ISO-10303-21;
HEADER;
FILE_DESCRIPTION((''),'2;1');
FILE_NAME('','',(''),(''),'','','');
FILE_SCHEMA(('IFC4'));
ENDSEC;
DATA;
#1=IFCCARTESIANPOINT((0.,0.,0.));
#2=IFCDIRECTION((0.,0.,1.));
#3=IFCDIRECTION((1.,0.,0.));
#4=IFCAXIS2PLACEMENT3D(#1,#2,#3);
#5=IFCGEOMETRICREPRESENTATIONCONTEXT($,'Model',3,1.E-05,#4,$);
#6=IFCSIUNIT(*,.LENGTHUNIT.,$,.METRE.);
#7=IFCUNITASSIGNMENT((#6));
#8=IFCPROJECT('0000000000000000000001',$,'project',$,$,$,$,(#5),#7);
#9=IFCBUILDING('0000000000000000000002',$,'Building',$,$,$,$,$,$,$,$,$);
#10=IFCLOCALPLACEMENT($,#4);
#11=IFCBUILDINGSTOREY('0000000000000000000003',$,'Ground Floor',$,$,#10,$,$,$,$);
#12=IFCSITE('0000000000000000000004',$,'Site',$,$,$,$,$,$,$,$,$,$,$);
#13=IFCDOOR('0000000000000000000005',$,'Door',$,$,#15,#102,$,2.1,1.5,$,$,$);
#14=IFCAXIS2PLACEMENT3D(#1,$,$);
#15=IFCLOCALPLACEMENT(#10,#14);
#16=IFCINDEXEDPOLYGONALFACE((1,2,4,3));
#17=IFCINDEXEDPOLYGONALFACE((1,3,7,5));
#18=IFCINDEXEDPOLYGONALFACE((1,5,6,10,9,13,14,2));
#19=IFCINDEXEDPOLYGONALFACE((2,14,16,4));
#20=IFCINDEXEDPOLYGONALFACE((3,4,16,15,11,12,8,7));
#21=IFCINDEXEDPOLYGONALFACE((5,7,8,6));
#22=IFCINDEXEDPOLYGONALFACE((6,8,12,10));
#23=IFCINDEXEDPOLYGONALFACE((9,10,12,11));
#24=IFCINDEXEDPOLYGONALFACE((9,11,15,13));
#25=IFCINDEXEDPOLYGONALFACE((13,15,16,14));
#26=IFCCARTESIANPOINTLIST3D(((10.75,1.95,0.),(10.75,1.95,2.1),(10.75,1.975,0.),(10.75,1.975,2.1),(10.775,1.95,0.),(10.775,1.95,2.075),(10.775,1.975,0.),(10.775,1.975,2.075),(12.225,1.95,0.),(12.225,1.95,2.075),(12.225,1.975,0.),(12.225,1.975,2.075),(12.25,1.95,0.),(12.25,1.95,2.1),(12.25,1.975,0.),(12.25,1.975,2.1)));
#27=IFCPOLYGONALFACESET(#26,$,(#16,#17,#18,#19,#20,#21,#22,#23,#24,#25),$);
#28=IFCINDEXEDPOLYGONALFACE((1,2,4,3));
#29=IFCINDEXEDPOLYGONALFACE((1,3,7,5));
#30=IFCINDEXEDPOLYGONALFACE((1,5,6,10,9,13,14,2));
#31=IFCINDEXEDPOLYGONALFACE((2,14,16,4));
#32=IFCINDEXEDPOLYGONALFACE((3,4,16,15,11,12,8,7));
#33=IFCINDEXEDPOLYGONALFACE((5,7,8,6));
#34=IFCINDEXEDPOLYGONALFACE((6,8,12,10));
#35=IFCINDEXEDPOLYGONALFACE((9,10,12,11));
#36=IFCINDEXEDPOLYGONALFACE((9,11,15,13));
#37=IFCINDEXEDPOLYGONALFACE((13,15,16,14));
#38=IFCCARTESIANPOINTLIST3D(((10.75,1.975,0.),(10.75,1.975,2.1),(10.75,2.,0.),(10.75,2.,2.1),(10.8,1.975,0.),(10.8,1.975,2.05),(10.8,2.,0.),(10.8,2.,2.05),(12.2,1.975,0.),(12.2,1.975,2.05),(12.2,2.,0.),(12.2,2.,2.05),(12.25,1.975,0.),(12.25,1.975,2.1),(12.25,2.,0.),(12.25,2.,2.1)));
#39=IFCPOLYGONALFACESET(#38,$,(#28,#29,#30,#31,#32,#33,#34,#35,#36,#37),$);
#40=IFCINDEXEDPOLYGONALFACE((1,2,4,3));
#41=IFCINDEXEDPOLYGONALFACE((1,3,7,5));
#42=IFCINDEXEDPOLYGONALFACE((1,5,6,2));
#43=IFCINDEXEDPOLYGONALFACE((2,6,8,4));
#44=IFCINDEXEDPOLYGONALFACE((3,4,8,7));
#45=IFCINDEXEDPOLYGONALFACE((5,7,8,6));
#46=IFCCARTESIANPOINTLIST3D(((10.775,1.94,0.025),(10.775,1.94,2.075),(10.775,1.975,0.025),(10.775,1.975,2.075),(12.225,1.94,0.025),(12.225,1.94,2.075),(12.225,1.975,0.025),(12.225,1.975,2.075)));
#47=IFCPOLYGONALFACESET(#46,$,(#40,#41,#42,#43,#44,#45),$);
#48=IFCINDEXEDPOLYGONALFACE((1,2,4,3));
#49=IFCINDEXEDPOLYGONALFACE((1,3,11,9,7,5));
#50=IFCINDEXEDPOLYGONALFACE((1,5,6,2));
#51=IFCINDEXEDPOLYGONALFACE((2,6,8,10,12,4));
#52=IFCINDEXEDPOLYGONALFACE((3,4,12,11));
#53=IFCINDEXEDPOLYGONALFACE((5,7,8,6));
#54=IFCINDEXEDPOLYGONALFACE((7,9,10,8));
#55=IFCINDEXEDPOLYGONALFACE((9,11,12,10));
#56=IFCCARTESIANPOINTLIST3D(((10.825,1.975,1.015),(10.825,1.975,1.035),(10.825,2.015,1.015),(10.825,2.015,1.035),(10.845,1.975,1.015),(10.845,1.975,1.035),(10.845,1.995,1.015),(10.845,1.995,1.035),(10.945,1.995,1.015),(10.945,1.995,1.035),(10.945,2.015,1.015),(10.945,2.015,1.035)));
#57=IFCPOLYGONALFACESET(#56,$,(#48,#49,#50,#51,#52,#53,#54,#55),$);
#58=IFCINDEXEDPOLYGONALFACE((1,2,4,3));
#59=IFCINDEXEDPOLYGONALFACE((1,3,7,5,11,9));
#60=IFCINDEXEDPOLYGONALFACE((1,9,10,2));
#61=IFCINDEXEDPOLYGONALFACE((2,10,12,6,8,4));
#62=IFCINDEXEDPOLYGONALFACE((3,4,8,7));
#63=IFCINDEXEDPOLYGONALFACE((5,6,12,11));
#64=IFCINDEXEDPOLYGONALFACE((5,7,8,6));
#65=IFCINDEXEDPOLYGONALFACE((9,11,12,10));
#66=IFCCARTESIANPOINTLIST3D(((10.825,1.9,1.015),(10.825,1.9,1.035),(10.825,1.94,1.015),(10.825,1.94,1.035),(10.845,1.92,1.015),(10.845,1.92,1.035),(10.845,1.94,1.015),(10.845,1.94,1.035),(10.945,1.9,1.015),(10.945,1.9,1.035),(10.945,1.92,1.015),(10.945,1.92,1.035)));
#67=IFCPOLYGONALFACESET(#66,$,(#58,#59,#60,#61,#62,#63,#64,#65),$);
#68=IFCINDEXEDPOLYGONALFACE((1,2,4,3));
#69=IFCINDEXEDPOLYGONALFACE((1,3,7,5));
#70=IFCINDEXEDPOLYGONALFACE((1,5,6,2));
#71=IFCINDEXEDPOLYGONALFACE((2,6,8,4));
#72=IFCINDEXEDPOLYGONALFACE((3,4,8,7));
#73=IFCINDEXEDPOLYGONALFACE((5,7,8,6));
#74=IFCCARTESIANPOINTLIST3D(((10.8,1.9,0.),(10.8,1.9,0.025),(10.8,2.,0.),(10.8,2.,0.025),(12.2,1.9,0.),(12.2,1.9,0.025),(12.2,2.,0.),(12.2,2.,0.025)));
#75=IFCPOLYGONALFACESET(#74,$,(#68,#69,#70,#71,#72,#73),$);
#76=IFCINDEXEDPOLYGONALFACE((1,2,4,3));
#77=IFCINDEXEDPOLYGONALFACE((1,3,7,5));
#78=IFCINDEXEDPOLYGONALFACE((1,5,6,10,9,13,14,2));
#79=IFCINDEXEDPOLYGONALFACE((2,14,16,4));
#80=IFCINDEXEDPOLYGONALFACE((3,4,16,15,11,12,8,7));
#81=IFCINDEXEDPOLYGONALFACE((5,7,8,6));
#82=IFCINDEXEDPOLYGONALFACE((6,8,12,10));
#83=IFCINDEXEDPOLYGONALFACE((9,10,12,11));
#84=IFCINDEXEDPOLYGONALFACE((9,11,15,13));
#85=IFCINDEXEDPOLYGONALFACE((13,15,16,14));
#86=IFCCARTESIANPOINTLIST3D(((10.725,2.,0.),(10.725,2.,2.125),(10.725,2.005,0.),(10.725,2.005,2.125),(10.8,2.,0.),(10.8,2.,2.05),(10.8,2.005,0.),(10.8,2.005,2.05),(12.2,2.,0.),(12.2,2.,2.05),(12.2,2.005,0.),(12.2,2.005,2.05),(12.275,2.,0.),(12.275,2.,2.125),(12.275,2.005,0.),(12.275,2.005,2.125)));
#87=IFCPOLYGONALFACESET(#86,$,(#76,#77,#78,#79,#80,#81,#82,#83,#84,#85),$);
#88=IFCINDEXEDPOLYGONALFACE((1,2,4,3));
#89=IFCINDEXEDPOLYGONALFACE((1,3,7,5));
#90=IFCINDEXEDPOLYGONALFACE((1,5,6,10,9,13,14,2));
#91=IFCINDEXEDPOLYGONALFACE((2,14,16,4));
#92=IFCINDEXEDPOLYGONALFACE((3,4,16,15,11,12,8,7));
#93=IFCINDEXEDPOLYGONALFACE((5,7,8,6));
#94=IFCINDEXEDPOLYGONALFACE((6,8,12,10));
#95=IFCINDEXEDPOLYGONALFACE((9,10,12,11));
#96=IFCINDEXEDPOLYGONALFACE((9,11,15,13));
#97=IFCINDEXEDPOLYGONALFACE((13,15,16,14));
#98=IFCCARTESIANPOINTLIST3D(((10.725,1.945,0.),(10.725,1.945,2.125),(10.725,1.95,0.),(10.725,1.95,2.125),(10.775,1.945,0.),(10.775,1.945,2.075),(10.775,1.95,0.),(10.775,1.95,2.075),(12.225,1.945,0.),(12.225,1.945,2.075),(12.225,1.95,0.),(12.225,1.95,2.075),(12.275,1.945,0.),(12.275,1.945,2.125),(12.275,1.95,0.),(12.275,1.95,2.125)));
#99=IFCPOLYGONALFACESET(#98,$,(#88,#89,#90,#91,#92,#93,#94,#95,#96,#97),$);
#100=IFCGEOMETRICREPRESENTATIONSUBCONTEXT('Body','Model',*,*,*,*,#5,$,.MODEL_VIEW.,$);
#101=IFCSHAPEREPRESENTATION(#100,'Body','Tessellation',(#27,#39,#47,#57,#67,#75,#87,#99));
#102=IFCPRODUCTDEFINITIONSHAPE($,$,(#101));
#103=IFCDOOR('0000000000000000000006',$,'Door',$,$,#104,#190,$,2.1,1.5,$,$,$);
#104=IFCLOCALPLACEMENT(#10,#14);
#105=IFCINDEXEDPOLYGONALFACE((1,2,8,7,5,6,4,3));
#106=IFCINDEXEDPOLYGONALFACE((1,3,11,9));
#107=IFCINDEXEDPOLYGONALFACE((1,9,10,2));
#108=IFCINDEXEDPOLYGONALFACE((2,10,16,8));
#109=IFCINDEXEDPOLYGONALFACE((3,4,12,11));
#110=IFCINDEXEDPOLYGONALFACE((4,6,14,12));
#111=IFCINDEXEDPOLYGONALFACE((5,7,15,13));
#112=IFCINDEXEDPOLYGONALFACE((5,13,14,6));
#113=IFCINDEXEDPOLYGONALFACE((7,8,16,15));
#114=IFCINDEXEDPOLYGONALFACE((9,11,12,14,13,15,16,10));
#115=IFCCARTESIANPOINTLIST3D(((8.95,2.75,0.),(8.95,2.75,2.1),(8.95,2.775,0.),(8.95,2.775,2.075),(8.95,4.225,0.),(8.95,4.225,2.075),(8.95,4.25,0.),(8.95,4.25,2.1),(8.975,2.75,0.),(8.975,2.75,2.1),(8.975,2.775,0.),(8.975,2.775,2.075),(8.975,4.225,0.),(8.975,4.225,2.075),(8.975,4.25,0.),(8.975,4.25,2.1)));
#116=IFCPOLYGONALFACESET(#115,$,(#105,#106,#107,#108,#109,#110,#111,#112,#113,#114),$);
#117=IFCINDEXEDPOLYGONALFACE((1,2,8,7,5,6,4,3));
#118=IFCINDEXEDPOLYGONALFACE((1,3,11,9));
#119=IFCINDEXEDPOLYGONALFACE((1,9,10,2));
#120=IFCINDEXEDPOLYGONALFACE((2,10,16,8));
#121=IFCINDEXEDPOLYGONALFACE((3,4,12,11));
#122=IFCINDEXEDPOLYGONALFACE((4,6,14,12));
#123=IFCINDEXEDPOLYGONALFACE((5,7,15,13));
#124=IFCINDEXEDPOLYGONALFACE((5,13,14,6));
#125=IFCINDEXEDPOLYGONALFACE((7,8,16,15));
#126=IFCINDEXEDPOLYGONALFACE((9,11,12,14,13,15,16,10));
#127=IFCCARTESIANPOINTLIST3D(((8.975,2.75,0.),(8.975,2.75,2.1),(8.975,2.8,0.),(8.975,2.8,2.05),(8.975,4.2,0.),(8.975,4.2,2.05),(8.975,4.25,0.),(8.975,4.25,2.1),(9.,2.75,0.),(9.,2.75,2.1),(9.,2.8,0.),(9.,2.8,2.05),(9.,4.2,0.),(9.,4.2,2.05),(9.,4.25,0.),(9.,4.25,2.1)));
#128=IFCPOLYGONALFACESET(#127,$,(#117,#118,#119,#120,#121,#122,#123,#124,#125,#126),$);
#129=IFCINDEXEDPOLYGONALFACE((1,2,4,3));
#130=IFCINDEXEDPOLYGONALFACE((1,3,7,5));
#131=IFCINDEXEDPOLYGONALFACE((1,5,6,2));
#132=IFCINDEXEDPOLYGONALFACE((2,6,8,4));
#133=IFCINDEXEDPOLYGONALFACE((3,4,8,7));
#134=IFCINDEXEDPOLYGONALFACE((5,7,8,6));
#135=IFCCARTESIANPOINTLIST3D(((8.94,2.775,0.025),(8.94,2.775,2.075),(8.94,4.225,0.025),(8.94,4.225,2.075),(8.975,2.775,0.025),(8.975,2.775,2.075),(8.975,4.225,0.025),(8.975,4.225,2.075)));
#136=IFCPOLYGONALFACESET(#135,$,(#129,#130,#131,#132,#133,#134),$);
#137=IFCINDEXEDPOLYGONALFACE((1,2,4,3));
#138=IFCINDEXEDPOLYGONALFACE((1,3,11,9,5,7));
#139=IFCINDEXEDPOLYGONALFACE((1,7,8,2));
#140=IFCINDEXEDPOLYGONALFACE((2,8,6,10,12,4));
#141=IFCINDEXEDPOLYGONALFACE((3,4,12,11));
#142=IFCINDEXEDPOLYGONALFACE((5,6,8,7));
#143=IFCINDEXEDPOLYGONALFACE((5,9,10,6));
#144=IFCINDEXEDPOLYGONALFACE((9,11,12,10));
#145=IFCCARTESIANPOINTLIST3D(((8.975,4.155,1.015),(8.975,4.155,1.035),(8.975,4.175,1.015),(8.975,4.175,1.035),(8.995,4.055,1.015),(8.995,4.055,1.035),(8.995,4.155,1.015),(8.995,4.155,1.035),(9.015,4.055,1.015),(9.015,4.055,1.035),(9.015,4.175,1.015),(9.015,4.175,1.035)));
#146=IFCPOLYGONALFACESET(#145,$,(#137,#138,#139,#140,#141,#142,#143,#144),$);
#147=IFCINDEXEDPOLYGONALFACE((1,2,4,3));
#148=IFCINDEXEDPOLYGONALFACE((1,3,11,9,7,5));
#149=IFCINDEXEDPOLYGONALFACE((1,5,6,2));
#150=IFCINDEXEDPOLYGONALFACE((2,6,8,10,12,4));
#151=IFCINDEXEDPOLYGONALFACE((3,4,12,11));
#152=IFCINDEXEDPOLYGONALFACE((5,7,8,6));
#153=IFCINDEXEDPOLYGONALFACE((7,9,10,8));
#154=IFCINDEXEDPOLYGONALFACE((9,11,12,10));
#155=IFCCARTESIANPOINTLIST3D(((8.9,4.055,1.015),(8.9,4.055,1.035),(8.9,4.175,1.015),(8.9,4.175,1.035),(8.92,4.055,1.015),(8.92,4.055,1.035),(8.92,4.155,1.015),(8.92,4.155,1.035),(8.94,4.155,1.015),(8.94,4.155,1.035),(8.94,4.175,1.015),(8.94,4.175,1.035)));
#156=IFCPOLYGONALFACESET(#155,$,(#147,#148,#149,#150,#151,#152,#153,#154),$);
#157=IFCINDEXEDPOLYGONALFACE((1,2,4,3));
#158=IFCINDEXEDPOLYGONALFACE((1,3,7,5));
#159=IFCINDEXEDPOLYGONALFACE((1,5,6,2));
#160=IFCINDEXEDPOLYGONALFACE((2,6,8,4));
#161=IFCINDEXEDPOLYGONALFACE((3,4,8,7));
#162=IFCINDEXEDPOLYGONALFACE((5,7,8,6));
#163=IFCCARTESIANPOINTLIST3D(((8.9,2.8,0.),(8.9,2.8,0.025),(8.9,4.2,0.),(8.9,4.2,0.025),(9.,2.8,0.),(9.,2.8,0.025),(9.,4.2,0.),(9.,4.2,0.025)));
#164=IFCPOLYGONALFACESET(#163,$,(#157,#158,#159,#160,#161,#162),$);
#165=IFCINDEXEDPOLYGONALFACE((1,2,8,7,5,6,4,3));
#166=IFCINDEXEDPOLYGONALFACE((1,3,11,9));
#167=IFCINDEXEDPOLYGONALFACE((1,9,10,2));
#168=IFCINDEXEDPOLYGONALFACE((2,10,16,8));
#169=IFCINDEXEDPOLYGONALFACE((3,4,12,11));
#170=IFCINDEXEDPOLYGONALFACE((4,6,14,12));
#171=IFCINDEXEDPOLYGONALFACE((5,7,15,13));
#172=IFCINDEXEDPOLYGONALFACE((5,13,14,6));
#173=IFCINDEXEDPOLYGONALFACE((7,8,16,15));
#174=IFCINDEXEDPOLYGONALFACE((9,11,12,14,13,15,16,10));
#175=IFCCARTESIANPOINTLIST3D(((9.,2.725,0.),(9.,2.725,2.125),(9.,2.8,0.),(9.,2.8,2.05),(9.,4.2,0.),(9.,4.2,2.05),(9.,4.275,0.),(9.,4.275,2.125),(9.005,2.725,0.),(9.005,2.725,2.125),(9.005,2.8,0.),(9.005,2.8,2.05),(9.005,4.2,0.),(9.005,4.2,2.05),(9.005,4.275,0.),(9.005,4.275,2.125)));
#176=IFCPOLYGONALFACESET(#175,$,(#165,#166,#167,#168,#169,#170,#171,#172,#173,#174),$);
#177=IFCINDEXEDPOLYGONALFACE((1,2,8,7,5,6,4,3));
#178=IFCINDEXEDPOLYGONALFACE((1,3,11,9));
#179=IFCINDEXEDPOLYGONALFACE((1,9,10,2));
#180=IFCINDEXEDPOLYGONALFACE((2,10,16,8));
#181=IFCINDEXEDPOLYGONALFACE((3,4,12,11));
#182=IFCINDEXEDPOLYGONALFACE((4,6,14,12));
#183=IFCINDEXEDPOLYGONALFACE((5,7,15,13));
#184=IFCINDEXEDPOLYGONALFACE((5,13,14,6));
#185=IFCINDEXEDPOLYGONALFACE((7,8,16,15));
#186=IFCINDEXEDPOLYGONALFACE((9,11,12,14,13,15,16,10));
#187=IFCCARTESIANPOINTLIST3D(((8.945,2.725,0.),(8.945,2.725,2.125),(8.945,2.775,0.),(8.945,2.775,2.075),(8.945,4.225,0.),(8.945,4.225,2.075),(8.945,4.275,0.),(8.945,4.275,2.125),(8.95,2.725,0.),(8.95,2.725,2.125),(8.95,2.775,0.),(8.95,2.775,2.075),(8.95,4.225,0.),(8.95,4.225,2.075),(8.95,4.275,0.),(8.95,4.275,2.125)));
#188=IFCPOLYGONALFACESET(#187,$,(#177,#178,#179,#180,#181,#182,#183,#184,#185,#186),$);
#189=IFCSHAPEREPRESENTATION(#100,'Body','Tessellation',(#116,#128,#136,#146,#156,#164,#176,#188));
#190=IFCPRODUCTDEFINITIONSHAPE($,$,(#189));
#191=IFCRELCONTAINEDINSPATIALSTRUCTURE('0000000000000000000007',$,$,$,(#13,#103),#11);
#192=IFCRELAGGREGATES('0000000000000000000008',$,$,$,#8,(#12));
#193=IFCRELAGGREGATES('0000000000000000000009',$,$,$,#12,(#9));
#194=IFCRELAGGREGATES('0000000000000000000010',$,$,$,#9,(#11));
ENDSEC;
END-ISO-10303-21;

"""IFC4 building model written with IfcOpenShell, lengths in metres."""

from ifc_helpers import new_model, si_unit, frame, origin_with_axes, place, context, subcontext, project, spatial, line, indexed_curve, outline, extrude, element, save


model = new_model("IFC4")

# Units and contexts
model_context = context("Model", 3, precision=1e-05, world=origin_with_axes())
body_context = subcontext(model_context, "Body", "Model", "MODEL_VIEW")
ifc_project = project(units=[si_unit("LENGTHUNIT", "METRE")], contexts=[model_context])

# Site, building, storey
site = spatial("IfcSite", under=ifc_project, Name="Site")
building = spatial("IfcBuilding", under=site, Name="Building")
storey_placement = place(None, origin_with_axes())
storey = spatial("IfcBuildingStorey", under=building, at=storey_placement, Name="Ground Floor")

# Doors
door_1_placement = place(storey_placement, frame((12.25, 2.0, 0.0), z_axis=(0.0, 0.0, 1.0), x_axis=(-1.0, 0.0, 0.0)))
element("IfcDoor", 1, at=door_1_placement, inside=storey, Name="Door", OverallHeight=2.1, OverallWidth=1.5, context=body_context, shape_type="SweptSolid", body=[
    extrude(outline(indexed_curve([(0.0, 0.0), (0.0, 2.1), (1.5, 2.1), (1.5, 0.0), (1.475, 0.0), (1.475, 2.075), (0.025, 2.075), (0.025, 0.0)], segments=[line(1, 2, 3, 4, 5, 6, 7, 8, 1)])), frame((0.0, 0.025, 0.0), z_axis=(0.0, -1.0, 0.0), x_axis=(1.0, 0.0, 0.0)), (0.0, 0.0, -1.0), 0.025),
    extrude(outline(indexed_curve([(0.0, 0.0), (0.0, 2.1), (1.5, 2.1), (1.5, 0.0), (1.45, 0.0), (1.45, 2.05), (0.05, 2.05), (0.05, 0.0)], segments=[line(1, 2, 3, 4, 5, 6, 7, 8, 1)])), frame((0.0, 0.0, 0.0), z_axis=(0.0, -1.0, 0.0), x_axis=(1.0, 0.0, 0.0)), (0.0, 0.0, -1.0), 0.025),
    extrude(outline(indexed_curve([(0.0, 0.0), (1.45, 0.0), (1.45, 0.035), (0.0, 0.035)], segments=[line(1, 2, 3, 4, 1)])), frame((0.025, 0.025, 0.025), z_axis=(0.0, 0.0, 1.0), x_axis=(1.0, 0.0, 0.0)), (0.0, 0.0, 1.0), 2.05),
    extrude(outline(indexed_curve([(0.0, 0.0), (0.0, -0.04), (-0.12, -0.04), (-0.12, -0.02), (-0.02, -0.02), (-0.02, 0.0)], segments=[line(1, 2, 3, 4, 5, 6, 1)])), frame((1.425, 0.025, 1.015), z_axis=(0.0, 0.0, 1.0), x_axis=(1.0, 0.0, 0.0)), (0.0, 0.0, 1.0), 0.02),
    extrude(outline(indexed_curve([(0.0, 0.0), (0.0, 0.04), (-0.12, 0.04), (-0.12, 0.02), (-0.02, 0.02), (-0.02, 0.0)], segments=[line(1, 2, 3, 4, 5, 6, 1)])), frame((1.425, 0.06, 1.015), z_axis=(0.0, 0.0, 1.0), x_axis=(1.0, 0.0, 0.0)), (0.0, 0.0, 1.0), 0.02),
    extrude(outline(indexed_curve([(0.0, 0.0), (1.4, 0.0), (1.4, 0.1), (0.0, 0.1)], segments=[line(1, 2, 3, 4, 1)])), frame((0.05, 0.0, 0.0), z_axis=(0.0, 0.0, 1.0), x_axis=(1.0, 0.0, 0.0)), (0.0, 0.0, 1.0), 0.025),
    extrude(outline(indexed_curve([(0.0, 0.0), (0.0, 2.125), (1.55, 2.125), (1.55, 0.0), (1.475, 0.0), (1.475, 2.05), (0.075, 2.05), (0.075, 0.0)], segments=[line(1, 2, 3, 4, 5, 6, 7, 8, 1)])), frame((-0.025, -0.005, 0.0), z_axis=(0.0, -1.0, 0.0), x_axis=(1.0, 0.0, 0.0)), (0.0, 0.0, -1.0), 0.005),
    extrude(outline(indexed_curve([(0.0, 0.0), (0.0, 2.125), (1.55, 2.125), (1.55, 0.0), (1.5, 0.0), (1.5, 2.075), (0.05, 2.075), (0.05, 0.0)], segments=[line(1, 2, 3, 4, 5, 6, 7, 8, 1)])), frame((-0.025, 0.05, 0.0), z_axis=(0.0, -1.0, 0.0), x_axis=(1.0, 0.0, 0.0)), (0.0, 0.0, -1.0), 0.005),
])
door_2_placement = place(storey_placement, frame((9.0, 2.75, 0.0), z_axis=(0.0, 0.0, 1.0), x_axis=(0.0, 1.0, 0.0)))
element("IfcDoor", 2, at=door_2_placement, inside=storey, Name="Door", OverallHeight=2.1, OverallWidth=1.5, context=body_context, shape_type="SweptSolid", body=[
    extrude(outline(indexed_curve([(0.0, 0.0), (0.0, 2.1), (1.5, 2.1), (1.5, 0.0), (1.475, 0.0), (1.475, 2.075), (0.025, 2.075), (0.025, 0.0)], segments=[line(1, 2, 3, 4, 5, 6, 7, 8, 1)])), frame((0.0, 0.025, 0.0), z_axis=(0.0, -1.0, 0.0), x_axis=(1.0, 0.0, 0.0)), (0.0, 0.0, -1.0), 0.025),
    extrude(outline(indexed_curve([(0.0, 0.0), (0.0, 2.1), (1.5, 2.1), (1.5, 0.0), (1.45, 0.0), (1.45, 2.05), (0.05, 2.05), (0.05, 0.0)], segments=[line(1, 2, 3, 4, 5, 6, 7, 8, 1)])), frame((0.0, 0.0, 0.0), z_axis=(0.0, -1.0, 0.0), x_axis=(1.0, 0.0, 0.0)), (0.0, 0.0, -1.0), 0.025),
    extrude(outline(indexed_curve([(0.0, 0.0), (1.45, 0.0), (1.45, 0.035), (0.0, 0.035)], segments=[line(1, 2, 3, 4, 1)])), frame((0.025, 0.025, 0.025), z_axis=(0.0, 0.0, 1.0), x_axis=(1.0, 0.0, 0.0)), (0.0, 0.0, 1.0), 2.05),
    extrude(outline(indexed_curve([(0.0, 0.0), (0.0, -0.04), (-0.12, -0.04), (-0.12, -0.02), (-0.02, -0.02), (-0.02, 0.0)], segments=[line(1, 2, 3, 4, 5, 6, 1)])), frame((1.425, 0.025, 1.015), z_axis=(0.0, 0.0, 1.0), x_axis=(1.0, 0.0, 0.0)), (0.0, 0.0, 1.0), 0.02),
    extrude(outline(indexed_curve([(0.0, 0.0), (0.0, 0.04), (-0.12, 0.04), (-0.12, 0.02), (-0.02, 0.02), (-0.02, 0.0)], segments=[line(1, 2, 3, 4, 5, 6, 1)])), frame((1.425, 0.06, 1.015), z_axis=(0.0, 0.0, 1.0), x_axis=(1.0, 0.0, 0.0)), (0.0, 0.0, 1.0), 0.02),
    extrude(outline(indexed_curve([(0.0, 0.0), (1.4, 0.0), (1.4, 0.1), (0.0, 0.1)], segments=[line(1, 2, 3, 4, 1)])), frame((0.05, 0.0, 0.0), z_axis=(0.0, 0.0, 1.0), x_axis=(1.0, 0.0, 0.0)), (0.0, 0.0, 1.0), 0.025),
    extrude(outline(indexed_curve([(0.0, 0.0), (0.0, 2.125), (1.55, 2.125), (1.55, 0.0), (1.475, 0.0), (1.475, 2.05), (0.075, 2.05), (0.075, 0.0)], segments=[line(1, 2, 3, 4, 5, 6, 7, 8, 1)])), frame((-0.025, -0.005, 0.0), z_axis=(0.0, -1.0, 0.0), x_axis=(1.0, 0.0, 0.0)), (0.0, 0.0, -1.0), 0.005),
    extrude(outline(indexed_curve([(0.0, 0.0), (0.0, 2.125), (1.55, 2.125), (1.55, 0.0), (1.5, 0.0), (1.5, 2.075), (0.05, 2.075), (0.05, 0.0)], segments=[line(1, 2, 3, 4, 5, 6, 7, 8, 1)])), frame((-0.025, 0.05, 0.0), z_axis=(0.0, -1.0, 0.0), x_axis=(1.0, 0.0, 0.0)), (0.0, 0.0, -1.0), 0.005),
])

save(model, "model.ifc")
